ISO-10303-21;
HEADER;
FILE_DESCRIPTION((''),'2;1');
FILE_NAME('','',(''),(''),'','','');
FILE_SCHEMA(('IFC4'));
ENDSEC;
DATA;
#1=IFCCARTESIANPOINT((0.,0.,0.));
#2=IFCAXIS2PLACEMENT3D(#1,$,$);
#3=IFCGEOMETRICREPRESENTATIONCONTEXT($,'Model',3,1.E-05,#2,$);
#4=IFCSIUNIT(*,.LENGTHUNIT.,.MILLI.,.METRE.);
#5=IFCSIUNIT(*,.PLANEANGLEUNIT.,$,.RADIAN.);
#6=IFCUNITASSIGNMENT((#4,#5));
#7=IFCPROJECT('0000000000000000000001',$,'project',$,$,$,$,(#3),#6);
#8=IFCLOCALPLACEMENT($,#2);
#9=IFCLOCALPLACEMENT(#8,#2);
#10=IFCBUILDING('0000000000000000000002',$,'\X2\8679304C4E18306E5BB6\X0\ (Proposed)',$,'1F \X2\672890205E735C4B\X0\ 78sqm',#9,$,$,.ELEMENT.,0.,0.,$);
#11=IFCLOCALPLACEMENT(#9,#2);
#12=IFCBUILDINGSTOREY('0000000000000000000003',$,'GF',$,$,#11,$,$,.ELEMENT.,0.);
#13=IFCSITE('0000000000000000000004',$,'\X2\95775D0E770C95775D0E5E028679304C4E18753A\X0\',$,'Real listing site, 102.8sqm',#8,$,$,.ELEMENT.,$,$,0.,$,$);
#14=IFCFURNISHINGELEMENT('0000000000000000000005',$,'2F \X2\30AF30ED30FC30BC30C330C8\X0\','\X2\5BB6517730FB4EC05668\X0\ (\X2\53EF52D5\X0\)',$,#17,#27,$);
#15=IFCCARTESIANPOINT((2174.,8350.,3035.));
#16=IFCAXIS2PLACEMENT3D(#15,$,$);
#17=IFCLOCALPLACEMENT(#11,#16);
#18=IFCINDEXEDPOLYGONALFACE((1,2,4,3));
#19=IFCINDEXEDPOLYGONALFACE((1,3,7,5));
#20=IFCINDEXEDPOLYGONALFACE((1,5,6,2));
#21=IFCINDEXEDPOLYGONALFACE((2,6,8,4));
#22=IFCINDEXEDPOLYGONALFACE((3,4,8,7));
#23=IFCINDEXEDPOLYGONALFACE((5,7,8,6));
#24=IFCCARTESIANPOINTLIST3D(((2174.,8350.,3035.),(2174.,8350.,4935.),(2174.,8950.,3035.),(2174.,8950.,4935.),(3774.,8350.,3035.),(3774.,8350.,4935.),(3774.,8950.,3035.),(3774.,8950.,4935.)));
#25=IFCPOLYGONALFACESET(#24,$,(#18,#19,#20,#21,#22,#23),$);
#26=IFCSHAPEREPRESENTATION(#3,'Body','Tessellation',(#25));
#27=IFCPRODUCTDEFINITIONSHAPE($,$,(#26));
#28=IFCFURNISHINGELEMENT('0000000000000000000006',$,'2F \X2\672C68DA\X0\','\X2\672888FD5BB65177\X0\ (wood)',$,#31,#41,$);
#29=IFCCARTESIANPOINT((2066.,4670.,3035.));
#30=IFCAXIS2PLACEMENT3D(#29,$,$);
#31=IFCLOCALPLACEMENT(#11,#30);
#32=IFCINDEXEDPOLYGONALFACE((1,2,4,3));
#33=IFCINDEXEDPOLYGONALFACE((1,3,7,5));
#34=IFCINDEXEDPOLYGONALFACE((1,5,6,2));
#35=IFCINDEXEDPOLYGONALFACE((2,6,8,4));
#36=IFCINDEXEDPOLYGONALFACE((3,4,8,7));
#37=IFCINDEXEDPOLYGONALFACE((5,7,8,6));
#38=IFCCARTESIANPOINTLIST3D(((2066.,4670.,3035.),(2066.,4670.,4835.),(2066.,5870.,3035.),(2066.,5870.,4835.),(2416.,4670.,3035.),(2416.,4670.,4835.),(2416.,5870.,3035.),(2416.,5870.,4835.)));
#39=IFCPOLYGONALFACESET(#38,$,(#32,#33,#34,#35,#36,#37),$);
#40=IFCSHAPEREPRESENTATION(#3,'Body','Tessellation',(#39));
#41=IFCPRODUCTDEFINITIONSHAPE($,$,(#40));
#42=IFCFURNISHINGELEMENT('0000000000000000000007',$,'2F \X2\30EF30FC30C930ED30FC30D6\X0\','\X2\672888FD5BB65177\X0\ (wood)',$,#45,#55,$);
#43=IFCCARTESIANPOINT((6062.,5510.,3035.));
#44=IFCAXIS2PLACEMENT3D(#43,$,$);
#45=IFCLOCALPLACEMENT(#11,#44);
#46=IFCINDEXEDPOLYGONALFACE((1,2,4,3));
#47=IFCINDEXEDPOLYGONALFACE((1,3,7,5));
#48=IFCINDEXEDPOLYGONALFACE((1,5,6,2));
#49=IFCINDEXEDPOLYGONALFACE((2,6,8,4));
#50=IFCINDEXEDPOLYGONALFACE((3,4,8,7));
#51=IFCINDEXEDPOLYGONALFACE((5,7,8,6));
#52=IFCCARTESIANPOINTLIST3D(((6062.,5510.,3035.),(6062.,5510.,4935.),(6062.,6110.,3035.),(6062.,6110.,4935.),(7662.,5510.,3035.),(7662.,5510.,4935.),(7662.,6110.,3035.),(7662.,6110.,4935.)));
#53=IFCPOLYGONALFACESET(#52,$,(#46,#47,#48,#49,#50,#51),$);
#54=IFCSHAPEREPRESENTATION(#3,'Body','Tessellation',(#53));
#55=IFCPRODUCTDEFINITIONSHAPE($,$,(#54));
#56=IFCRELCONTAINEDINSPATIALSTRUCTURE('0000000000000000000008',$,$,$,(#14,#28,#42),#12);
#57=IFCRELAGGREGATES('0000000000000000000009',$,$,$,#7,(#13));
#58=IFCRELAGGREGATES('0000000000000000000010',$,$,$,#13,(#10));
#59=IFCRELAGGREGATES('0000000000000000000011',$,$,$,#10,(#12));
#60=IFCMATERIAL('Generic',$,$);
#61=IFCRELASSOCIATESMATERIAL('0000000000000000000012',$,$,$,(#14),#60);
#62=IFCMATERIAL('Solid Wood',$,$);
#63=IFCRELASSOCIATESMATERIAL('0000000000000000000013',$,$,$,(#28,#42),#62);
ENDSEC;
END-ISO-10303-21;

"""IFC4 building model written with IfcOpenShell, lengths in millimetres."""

from ifc_helpers import new_model, si_unit, frame, frame_2d, origin, place, context, project, spatial, rectangle, extrude, material, element, save


model = new_model("IFC4")

# Units and contexts
model_context = context("Model", 3, precision=1e-05, world=origin())
ifc_project = project(units=[si_unit("LENGTHUNIT", "METRE", prefix="MILLI"), si_unit("PLANEANGLEUNIT", "RADIAN")], contexts=[model_context])

# Site, building, storey
site_placement = place(None, origin())
site = spatial("IfcSite", under=ifc_project, at=site_placement, Name="長崎県長崎市虹が丘町", ObjectType="Real listing site, 102.8sqm", CompositionType="ELEMENT", RefElevation=0.0)
building_placement = place(site_placement, origin())
building = spatial("IfcBuilding", under=site, at=building_placement, Name="虹が丘の家 (Proposed)", ObjectType="1F 木造平屋 78sqm", CompositionType="ELEMENT", ElevationOfRefHeight=0.0, ElevationOfTerrain=0.0)
storey_placement = place(building_placement, origin())
storey = spatial("IfcBuildingStorey", under=building, at=storey_placement, Name="GF", CompositionType="ELEMENT", Elevation=0.0)

# Shared definitions
ifc_material_1 = material(Name="Solid Wood")

# Shared definitions
ifc_material_2 = material(Name="Generic")

# Furnishing elements
furnishing_1_placement = place(storey_placement, frame((2174.0, 8350.0, 3035.0)))
element("IfcFurnishingElement", 1, at=furnishing_1_placement, inside=storey, material=ifc_material_2, Name="2F クローゼット", Description="家具・什器 (可動)", context=model_context, shape_type="SweptSolid", body=[
    extrude(rectangle(XDim=1600.0, YDim=600.0, at=frame_2d((800.0, 300.0))), frame((2174.0, 8350.0, 3035.0)), (0.0, 0.0, 1.0), 1900.0),
])
furnishing_2_placement = place(storey_placement, frame((2066.0, 4670.0, 3035.0)))
element("IfcFurnishingElement", 2, at=furnishing_2_placement, inside=storey, material=ifc_material_1, Name="2F 本棚", Description="木製家具 (wood)", context=model_context, shape_type="SweptSolid", body=[
    extrude(rectangle(XDim=350.0, YDim=1200.0, at=frame_2d((175.0, 600.0))), frame((2066.0, 4670.0, 3035.0)), (0.0, 0.0, 1.0), 1800.0),
])
furnishing_3_placement = place(storey_placement, frame((6062.0, 5510.0, 3035.0)))
element("IfcFurnishingElement", 3, at=furnishing_3_placement, inside=storey, material=ifc_material_1, Name="2F ワードローブ", Description="木製家具 (wood)", context=model_context, shape_type="SweptSolid", body=[
    extrude(rectangle(XDim=1600.0, YDim=600.0, at=frame_2d((800.0, 300.0))), frame((6062.0, 5510.0, 3035.0)), (0.0, 0.0, 1.0), 1900.0),
])

save(model, "model.ifc")
